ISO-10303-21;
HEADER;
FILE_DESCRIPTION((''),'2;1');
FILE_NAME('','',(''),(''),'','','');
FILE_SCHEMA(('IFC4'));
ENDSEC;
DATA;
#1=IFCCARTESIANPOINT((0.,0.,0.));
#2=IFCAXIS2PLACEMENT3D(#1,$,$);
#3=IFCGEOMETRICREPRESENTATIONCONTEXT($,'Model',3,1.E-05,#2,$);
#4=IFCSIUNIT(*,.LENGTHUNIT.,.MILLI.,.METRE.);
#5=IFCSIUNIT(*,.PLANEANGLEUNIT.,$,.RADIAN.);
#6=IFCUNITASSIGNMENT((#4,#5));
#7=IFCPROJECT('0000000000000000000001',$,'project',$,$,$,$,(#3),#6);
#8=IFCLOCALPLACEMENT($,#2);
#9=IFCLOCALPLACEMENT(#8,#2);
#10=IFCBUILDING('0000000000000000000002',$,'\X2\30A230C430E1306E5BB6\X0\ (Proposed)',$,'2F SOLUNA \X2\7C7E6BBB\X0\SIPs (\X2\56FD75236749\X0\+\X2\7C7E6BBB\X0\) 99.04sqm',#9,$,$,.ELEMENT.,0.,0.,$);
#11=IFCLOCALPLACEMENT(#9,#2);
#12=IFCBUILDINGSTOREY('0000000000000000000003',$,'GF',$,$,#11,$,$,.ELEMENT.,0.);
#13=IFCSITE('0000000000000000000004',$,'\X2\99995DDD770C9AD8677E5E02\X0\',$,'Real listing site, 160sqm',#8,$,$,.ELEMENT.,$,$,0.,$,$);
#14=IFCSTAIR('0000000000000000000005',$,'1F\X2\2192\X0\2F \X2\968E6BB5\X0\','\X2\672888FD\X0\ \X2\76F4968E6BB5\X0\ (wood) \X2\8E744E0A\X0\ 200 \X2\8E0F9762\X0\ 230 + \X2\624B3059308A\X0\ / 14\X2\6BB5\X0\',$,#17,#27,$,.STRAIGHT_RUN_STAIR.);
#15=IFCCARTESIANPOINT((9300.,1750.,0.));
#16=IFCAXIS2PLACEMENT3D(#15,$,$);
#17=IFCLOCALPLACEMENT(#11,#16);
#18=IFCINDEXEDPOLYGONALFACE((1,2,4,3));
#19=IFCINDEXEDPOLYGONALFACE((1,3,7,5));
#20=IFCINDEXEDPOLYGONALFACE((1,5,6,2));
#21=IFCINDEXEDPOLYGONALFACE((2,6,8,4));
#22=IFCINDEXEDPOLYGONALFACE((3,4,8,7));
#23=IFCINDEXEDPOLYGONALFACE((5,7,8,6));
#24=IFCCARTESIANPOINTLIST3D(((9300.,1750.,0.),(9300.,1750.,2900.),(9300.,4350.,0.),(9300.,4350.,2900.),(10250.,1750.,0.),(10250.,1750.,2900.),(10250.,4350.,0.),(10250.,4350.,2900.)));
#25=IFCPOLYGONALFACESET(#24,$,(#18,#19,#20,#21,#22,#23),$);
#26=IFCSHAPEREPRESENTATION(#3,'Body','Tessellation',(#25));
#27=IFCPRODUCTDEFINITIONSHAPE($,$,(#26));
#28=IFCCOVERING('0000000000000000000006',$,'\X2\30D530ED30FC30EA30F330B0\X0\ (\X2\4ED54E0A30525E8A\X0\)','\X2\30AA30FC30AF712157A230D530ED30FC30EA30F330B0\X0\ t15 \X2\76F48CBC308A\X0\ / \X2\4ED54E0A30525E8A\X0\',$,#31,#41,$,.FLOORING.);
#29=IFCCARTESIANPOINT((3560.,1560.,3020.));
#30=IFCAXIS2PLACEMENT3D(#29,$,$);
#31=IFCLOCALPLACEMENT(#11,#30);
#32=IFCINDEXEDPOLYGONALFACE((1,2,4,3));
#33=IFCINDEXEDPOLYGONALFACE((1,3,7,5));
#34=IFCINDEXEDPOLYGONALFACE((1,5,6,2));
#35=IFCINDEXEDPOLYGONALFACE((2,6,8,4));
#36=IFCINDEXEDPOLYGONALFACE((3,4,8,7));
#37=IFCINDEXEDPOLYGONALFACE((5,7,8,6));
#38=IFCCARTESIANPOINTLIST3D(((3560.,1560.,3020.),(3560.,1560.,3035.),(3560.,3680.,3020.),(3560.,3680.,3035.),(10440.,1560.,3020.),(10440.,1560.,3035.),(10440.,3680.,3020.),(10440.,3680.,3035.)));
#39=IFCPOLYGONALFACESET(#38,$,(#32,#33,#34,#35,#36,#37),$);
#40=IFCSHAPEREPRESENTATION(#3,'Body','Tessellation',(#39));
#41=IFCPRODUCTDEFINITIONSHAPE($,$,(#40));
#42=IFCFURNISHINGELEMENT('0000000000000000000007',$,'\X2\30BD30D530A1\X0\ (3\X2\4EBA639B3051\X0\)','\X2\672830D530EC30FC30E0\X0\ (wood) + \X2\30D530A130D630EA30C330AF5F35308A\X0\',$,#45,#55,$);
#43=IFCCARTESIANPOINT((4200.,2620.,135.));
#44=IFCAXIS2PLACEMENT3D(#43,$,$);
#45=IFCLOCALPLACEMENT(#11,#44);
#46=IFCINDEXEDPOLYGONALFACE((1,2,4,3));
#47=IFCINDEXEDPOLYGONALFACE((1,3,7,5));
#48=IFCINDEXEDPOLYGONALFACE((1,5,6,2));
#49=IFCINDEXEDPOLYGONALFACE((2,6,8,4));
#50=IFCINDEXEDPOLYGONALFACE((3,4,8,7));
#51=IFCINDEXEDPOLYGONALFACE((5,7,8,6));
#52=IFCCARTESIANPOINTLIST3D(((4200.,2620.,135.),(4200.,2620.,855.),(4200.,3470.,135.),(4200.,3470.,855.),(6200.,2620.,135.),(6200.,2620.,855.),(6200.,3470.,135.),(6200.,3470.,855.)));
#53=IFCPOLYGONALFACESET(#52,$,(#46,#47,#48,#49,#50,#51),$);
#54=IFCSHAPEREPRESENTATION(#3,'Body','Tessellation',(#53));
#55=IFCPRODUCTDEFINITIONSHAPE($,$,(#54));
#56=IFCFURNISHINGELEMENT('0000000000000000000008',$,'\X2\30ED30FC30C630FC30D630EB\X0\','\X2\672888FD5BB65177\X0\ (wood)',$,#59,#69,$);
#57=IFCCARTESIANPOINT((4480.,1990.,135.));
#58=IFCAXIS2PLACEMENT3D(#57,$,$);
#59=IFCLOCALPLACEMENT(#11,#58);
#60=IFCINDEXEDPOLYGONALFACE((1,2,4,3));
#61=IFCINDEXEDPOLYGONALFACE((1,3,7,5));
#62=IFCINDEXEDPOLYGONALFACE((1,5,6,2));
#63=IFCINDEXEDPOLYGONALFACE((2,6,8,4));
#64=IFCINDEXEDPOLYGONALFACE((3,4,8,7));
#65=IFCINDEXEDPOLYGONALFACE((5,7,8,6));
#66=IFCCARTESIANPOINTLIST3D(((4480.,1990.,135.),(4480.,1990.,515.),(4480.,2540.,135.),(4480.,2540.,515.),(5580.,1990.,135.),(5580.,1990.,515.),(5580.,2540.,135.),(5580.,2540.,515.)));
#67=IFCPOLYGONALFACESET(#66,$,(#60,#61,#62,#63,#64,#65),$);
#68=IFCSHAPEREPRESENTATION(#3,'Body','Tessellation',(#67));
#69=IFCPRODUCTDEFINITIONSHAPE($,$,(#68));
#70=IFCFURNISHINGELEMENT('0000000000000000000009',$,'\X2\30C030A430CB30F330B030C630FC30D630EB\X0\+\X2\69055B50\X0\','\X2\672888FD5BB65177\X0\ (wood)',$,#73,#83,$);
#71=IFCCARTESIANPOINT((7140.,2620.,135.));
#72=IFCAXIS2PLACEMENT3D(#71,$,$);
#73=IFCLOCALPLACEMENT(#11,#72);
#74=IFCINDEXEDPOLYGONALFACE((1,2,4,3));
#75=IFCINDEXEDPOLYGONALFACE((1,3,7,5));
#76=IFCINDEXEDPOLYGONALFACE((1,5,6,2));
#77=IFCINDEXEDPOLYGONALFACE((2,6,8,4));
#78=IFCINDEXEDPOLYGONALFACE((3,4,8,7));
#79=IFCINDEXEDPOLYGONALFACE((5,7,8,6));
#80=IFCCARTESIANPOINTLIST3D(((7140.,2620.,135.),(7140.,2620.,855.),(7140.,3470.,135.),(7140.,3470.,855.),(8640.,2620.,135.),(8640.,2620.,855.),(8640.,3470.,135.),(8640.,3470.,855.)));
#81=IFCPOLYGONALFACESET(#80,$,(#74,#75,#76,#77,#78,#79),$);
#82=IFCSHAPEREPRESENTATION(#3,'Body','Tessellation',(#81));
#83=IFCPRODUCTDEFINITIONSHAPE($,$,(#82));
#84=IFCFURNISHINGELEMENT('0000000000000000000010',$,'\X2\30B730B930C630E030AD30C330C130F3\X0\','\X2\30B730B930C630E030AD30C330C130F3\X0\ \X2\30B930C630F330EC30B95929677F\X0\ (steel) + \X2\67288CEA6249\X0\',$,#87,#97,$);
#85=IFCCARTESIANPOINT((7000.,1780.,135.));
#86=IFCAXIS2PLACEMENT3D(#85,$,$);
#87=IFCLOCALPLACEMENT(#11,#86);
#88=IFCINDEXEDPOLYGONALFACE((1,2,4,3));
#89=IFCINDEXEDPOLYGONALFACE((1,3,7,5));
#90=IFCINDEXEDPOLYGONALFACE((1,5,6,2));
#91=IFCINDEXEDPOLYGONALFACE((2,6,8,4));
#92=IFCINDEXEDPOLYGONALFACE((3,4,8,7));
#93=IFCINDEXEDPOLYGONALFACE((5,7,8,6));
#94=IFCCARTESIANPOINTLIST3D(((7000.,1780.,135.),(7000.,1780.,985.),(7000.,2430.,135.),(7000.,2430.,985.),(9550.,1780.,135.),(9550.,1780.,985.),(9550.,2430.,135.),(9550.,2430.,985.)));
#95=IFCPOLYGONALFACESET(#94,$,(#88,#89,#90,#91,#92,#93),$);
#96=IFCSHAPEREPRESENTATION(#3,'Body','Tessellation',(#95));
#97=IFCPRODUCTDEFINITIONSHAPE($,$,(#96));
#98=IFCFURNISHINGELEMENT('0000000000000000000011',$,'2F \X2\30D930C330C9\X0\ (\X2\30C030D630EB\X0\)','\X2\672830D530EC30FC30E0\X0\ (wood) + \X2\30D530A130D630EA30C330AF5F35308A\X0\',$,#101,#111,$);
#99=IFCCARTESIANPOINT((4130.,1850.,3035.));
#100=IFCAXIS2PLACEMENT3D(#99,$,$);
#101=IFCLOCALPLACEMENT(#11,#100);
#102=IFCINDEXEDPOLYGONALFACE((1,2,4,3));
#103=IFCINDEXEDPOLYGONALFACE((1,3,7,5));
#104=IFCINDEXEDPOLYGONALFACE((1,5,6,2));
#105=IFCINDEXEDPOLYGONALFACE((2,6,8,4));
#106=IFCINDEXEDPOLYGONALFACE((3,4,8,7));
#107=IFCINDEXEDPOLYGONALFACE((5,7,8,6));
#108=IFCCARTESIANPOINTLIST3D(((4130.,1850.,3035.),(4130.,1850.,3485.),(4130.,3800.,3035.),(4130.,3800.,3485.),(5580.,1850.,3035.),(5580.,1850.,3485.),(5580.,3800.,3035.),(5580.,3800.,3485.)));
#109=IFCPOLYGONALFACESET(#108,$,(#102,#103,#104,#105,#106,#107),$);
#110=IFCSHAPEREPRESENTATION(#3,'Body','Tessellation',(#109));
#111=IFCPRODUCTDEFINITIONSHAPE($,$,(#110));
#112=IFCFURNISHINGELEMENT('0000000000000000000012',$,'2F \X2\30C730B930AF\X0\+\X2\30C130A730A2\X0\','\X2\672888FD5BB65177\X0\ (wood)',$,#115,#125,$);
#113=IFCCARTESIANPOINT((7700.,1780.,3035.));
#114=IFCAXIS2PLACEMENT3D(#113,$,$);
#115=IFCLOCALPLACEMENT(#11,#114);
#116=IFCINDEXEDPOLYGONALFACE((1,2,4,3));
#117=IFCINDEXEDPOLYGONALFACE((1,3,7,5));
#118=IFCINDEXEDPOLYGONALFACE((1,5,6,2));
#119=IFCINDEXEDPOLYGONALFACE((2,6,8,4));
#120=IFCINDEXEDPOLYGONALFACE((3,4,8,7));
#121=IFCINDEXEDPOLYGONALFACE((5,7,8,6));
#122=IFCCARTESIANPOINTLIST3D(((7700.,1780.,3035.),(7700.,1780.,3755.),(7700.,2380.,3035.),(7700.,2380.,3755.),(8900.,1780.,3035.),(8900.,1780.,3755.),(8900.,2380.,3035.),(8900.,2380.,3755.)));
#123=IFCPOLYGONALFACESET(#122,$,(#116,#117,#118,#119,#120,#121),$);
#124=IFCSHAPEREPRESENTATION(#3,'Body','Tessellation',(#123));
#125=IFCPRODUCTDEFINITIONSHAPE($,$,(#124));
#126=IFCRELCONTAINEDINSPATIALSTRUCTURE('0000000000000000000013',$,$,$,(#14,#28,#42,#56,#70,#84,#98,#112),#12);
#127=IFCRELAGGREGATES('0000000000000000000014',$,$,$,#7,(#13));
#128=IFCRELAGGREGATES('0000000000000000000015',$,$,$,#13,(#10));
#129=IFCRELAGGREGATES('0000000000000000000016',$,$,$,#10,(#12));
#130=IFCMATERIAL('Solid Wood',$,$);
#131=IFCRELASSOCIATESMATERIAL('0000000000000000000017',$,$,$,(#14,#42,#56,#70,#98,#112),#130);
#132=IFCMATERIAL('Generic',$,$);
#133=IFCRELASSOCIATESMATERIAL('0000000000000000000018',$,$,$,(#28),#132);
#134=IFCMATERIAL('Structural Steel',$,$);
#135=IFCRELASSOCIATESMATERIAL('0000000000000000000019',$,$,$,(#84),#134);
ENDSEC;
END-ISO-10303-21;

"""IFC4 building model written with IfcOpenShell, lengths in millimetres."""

from ifc_helpers import new_model, si_unit, frame, frame_2d, origin, place, context, project, spatial, rectangle, extrude, material, element, save


model = new_model("IFC4")

# Units and contexts
model_context = context("Model", 3, precision=1e-05, world=origin())
ifc_project = project(units=[si_unit("LENGTHUNIT", "METRE", prefix="MILLI"), si_unit("PLANEANGLEUNIT", "RADIAN")], contexts=[model_context])

# Site, building, storey
site_placement = place(None, origin())
site = spatial("IfcSite", under=ifc_project, at=site_placement, Name="香川県高松市", ObjectType="Real listing site, 160sqm", CompositionType="ELEMENT", RefElevation=0.0)
building_placement = place(site_placement, origin())
building = spatial("IfcBuilding", under=site, at=building_placement, Name="アツメの家 (Proposed)", ObjectType="2F SOLUNA 籾殻SIPs (国産杉+籾殻) 99.04sqm", CompositionType="ELEMENT", ElevationOfRefHeight=0.0, ElevationOfTerrain=0.0)
storey_placement = place(building_placement, origin())
storey = spatial("IfcBuildingStorey", under=building, at=storey_placement, Name="GF", CompositionType="ELEMENT", Elevation=0.0)

# Shared definitions
ifc_material_1 = material(Name="Solid Wood")

# Shared definitions
ifc_material_2 = material(Name="Generic")

# Stair
stair_placement = place(storey_placement, frame((9300.0, 1750.0, 0.0)))
element("IfcStair", 1, at=stair_placement, inside=storey, material=ifc_material_1, Name="1F→2F 階段", Description="木製 直階段 (wood) 蹴上 200 踏面 230 + 手すり / 14段", PredefinedType="STRAIGHT_RUN_STAIR", context=model_context, shape_type="SweptSolid", body=[
    extrude(rectangle(XDim=950.0, YDim=2600.0, at=frame_2d((475.0, 1300.0))), frame((9300.0, 1750.0, 0.0)), (0.0, 0.0, 1.0), 2900.0),
])

# Covering
covering_placement = place(storey_placement, frame((3560.0, 1560.0, 3020.0)))
element("IfcCovering", 2, at=covering_placement, inside=storey, material=ifc_material_2, Name="フローリング (仕上げ床)", Description="オーク無垢フローリング t15 直貼り / 仕上げ床", PredefinedType="FLOORING", context=model_context, shape_type="SweptSolid", body=[
    extrude(rectangle(XDim=6880.0, YDim=2120.0, at=frame_2d((3440.0, 1060.0))), frame((3560.0, 1560.0, 3020.0)), (0.0, 0.0, 1.0), 15.0),
])

# Furnishing elements
furnishing_1_placement = place(storey_placement, frame((4200.0, 2620.0, 135.0)))
element("IfcFurnishingElement", 3, at=furnishing_1_placement, inside=storey, material=ifc_material_1, Name="ソファ (3人掛け)", Description="木フレーム (wood) + ファブリック張り", context=model_context, shape_type="SweptSolid", body=[
    extrude(rectangle(XDim=2000.0, YDim=850.0, at=frame_2d((1000.0, 425.0))), frame((4200.0, 2620.0, 135.0)), (0.0, 0.0, 1.0), 720.0),
])
furnishing_2_placement = place(storey_placement, frame((4480.0, 1990.0, 135.0)))
element("IfcFurnishingElement", 4, at=furnishing_2_placement, inside=storey, material=ifc_material_1, Name="ローテーブル", Description="木製家具 (wood)", context=model_context, shape_type="SweptSolid", body=[
    extrude(rectangle(XDim=1100.0, YDim=550.0, at=frame_2d((550.0, 275.0))), frame((4480.0, 1990.0, 135.0)), (0.0, 0.0, 1.0), 380.0),
])
furnishing_3_placement = place(storey_placement, frame((7140.0, 2620.0, 135.0)))
element("IfcFurnishingElement", 5, at=furnishing_3_placement, inside=storey, material=ifc_material_1, Name="ダイニングテーブル+椅子", Description="木製家具 (wood)", context=model_context, shape_type="SweptSolid", body=[
    extrude(rectangle(XDim=1500.0, YDim=850.0, at=frame_2d((750.0, 425.0))), frame((7140.0, 2620.0, 135.0)), (0.0, 0.0, 1.0), 720.0),
])
ifc_material_3 = material(Name="Structural Steel")
furnishing_4_placement = place(storey_placement, frame((7000.0, 1780.0, 135.0)))
element("IfcFurnishingElement", 6, at=furnishing_4_placement, inside=storey, material=ifc_material_3, Name="システムキッチン", Description="システムキッチン ステンレス天板 (steel) + 木質扉", context=model_context, shape_type="SweptSolid", body=[
    extrude(rectangle(XDim=2550.0, YDim=650.0, at=frame_2d((1275.0, 325.0))), frame((7000.0, 1780.0, 135.0)), (0.0, 0.0, 1.0), 850.0),
])
furnishing_5_placement = place(storey_placement, frame((4130.0, 1850.0, 3035.0)))
element("IfcFurnishingElement", 7, at=furnishing_5_placement, inside=storey, material=ifc_material_1, Name="2F ベッド (ダブル)", Description="木フレーム (wood) + ファブリック張り", context=model_context, shape_type="SweptSolid", body=[
    extrude(rectangle(XDim=1450.0, YDim=1950.0, at=frame_2d((725.0, 975.0))), frame((4130.0, 1850.0, 3035.0)), (0.0, 0.0, 1.0), 450.0),
])
furnishing_6_placement = place(storey_placement, frame((7700.0, 1780.0, 3035.0)))
element("IfcFurnishingElement", 8, at=furnishing_6_placement, inside=storey, material=ifc_material_1, Name="2F デスク+チェア", Description="木製家具 (wood)", context=model_context, shape_type="SweptSolid", body=[
    extrude(rectangle(XDim=1200.0, YDim=600.0, at=frame_2d((600.0, 300.0))), frame((7700.0, 1780.0, 3035.0)), (0.0, 0.0, 1.0), 720.0),
])

save(model, "model.ifc")
